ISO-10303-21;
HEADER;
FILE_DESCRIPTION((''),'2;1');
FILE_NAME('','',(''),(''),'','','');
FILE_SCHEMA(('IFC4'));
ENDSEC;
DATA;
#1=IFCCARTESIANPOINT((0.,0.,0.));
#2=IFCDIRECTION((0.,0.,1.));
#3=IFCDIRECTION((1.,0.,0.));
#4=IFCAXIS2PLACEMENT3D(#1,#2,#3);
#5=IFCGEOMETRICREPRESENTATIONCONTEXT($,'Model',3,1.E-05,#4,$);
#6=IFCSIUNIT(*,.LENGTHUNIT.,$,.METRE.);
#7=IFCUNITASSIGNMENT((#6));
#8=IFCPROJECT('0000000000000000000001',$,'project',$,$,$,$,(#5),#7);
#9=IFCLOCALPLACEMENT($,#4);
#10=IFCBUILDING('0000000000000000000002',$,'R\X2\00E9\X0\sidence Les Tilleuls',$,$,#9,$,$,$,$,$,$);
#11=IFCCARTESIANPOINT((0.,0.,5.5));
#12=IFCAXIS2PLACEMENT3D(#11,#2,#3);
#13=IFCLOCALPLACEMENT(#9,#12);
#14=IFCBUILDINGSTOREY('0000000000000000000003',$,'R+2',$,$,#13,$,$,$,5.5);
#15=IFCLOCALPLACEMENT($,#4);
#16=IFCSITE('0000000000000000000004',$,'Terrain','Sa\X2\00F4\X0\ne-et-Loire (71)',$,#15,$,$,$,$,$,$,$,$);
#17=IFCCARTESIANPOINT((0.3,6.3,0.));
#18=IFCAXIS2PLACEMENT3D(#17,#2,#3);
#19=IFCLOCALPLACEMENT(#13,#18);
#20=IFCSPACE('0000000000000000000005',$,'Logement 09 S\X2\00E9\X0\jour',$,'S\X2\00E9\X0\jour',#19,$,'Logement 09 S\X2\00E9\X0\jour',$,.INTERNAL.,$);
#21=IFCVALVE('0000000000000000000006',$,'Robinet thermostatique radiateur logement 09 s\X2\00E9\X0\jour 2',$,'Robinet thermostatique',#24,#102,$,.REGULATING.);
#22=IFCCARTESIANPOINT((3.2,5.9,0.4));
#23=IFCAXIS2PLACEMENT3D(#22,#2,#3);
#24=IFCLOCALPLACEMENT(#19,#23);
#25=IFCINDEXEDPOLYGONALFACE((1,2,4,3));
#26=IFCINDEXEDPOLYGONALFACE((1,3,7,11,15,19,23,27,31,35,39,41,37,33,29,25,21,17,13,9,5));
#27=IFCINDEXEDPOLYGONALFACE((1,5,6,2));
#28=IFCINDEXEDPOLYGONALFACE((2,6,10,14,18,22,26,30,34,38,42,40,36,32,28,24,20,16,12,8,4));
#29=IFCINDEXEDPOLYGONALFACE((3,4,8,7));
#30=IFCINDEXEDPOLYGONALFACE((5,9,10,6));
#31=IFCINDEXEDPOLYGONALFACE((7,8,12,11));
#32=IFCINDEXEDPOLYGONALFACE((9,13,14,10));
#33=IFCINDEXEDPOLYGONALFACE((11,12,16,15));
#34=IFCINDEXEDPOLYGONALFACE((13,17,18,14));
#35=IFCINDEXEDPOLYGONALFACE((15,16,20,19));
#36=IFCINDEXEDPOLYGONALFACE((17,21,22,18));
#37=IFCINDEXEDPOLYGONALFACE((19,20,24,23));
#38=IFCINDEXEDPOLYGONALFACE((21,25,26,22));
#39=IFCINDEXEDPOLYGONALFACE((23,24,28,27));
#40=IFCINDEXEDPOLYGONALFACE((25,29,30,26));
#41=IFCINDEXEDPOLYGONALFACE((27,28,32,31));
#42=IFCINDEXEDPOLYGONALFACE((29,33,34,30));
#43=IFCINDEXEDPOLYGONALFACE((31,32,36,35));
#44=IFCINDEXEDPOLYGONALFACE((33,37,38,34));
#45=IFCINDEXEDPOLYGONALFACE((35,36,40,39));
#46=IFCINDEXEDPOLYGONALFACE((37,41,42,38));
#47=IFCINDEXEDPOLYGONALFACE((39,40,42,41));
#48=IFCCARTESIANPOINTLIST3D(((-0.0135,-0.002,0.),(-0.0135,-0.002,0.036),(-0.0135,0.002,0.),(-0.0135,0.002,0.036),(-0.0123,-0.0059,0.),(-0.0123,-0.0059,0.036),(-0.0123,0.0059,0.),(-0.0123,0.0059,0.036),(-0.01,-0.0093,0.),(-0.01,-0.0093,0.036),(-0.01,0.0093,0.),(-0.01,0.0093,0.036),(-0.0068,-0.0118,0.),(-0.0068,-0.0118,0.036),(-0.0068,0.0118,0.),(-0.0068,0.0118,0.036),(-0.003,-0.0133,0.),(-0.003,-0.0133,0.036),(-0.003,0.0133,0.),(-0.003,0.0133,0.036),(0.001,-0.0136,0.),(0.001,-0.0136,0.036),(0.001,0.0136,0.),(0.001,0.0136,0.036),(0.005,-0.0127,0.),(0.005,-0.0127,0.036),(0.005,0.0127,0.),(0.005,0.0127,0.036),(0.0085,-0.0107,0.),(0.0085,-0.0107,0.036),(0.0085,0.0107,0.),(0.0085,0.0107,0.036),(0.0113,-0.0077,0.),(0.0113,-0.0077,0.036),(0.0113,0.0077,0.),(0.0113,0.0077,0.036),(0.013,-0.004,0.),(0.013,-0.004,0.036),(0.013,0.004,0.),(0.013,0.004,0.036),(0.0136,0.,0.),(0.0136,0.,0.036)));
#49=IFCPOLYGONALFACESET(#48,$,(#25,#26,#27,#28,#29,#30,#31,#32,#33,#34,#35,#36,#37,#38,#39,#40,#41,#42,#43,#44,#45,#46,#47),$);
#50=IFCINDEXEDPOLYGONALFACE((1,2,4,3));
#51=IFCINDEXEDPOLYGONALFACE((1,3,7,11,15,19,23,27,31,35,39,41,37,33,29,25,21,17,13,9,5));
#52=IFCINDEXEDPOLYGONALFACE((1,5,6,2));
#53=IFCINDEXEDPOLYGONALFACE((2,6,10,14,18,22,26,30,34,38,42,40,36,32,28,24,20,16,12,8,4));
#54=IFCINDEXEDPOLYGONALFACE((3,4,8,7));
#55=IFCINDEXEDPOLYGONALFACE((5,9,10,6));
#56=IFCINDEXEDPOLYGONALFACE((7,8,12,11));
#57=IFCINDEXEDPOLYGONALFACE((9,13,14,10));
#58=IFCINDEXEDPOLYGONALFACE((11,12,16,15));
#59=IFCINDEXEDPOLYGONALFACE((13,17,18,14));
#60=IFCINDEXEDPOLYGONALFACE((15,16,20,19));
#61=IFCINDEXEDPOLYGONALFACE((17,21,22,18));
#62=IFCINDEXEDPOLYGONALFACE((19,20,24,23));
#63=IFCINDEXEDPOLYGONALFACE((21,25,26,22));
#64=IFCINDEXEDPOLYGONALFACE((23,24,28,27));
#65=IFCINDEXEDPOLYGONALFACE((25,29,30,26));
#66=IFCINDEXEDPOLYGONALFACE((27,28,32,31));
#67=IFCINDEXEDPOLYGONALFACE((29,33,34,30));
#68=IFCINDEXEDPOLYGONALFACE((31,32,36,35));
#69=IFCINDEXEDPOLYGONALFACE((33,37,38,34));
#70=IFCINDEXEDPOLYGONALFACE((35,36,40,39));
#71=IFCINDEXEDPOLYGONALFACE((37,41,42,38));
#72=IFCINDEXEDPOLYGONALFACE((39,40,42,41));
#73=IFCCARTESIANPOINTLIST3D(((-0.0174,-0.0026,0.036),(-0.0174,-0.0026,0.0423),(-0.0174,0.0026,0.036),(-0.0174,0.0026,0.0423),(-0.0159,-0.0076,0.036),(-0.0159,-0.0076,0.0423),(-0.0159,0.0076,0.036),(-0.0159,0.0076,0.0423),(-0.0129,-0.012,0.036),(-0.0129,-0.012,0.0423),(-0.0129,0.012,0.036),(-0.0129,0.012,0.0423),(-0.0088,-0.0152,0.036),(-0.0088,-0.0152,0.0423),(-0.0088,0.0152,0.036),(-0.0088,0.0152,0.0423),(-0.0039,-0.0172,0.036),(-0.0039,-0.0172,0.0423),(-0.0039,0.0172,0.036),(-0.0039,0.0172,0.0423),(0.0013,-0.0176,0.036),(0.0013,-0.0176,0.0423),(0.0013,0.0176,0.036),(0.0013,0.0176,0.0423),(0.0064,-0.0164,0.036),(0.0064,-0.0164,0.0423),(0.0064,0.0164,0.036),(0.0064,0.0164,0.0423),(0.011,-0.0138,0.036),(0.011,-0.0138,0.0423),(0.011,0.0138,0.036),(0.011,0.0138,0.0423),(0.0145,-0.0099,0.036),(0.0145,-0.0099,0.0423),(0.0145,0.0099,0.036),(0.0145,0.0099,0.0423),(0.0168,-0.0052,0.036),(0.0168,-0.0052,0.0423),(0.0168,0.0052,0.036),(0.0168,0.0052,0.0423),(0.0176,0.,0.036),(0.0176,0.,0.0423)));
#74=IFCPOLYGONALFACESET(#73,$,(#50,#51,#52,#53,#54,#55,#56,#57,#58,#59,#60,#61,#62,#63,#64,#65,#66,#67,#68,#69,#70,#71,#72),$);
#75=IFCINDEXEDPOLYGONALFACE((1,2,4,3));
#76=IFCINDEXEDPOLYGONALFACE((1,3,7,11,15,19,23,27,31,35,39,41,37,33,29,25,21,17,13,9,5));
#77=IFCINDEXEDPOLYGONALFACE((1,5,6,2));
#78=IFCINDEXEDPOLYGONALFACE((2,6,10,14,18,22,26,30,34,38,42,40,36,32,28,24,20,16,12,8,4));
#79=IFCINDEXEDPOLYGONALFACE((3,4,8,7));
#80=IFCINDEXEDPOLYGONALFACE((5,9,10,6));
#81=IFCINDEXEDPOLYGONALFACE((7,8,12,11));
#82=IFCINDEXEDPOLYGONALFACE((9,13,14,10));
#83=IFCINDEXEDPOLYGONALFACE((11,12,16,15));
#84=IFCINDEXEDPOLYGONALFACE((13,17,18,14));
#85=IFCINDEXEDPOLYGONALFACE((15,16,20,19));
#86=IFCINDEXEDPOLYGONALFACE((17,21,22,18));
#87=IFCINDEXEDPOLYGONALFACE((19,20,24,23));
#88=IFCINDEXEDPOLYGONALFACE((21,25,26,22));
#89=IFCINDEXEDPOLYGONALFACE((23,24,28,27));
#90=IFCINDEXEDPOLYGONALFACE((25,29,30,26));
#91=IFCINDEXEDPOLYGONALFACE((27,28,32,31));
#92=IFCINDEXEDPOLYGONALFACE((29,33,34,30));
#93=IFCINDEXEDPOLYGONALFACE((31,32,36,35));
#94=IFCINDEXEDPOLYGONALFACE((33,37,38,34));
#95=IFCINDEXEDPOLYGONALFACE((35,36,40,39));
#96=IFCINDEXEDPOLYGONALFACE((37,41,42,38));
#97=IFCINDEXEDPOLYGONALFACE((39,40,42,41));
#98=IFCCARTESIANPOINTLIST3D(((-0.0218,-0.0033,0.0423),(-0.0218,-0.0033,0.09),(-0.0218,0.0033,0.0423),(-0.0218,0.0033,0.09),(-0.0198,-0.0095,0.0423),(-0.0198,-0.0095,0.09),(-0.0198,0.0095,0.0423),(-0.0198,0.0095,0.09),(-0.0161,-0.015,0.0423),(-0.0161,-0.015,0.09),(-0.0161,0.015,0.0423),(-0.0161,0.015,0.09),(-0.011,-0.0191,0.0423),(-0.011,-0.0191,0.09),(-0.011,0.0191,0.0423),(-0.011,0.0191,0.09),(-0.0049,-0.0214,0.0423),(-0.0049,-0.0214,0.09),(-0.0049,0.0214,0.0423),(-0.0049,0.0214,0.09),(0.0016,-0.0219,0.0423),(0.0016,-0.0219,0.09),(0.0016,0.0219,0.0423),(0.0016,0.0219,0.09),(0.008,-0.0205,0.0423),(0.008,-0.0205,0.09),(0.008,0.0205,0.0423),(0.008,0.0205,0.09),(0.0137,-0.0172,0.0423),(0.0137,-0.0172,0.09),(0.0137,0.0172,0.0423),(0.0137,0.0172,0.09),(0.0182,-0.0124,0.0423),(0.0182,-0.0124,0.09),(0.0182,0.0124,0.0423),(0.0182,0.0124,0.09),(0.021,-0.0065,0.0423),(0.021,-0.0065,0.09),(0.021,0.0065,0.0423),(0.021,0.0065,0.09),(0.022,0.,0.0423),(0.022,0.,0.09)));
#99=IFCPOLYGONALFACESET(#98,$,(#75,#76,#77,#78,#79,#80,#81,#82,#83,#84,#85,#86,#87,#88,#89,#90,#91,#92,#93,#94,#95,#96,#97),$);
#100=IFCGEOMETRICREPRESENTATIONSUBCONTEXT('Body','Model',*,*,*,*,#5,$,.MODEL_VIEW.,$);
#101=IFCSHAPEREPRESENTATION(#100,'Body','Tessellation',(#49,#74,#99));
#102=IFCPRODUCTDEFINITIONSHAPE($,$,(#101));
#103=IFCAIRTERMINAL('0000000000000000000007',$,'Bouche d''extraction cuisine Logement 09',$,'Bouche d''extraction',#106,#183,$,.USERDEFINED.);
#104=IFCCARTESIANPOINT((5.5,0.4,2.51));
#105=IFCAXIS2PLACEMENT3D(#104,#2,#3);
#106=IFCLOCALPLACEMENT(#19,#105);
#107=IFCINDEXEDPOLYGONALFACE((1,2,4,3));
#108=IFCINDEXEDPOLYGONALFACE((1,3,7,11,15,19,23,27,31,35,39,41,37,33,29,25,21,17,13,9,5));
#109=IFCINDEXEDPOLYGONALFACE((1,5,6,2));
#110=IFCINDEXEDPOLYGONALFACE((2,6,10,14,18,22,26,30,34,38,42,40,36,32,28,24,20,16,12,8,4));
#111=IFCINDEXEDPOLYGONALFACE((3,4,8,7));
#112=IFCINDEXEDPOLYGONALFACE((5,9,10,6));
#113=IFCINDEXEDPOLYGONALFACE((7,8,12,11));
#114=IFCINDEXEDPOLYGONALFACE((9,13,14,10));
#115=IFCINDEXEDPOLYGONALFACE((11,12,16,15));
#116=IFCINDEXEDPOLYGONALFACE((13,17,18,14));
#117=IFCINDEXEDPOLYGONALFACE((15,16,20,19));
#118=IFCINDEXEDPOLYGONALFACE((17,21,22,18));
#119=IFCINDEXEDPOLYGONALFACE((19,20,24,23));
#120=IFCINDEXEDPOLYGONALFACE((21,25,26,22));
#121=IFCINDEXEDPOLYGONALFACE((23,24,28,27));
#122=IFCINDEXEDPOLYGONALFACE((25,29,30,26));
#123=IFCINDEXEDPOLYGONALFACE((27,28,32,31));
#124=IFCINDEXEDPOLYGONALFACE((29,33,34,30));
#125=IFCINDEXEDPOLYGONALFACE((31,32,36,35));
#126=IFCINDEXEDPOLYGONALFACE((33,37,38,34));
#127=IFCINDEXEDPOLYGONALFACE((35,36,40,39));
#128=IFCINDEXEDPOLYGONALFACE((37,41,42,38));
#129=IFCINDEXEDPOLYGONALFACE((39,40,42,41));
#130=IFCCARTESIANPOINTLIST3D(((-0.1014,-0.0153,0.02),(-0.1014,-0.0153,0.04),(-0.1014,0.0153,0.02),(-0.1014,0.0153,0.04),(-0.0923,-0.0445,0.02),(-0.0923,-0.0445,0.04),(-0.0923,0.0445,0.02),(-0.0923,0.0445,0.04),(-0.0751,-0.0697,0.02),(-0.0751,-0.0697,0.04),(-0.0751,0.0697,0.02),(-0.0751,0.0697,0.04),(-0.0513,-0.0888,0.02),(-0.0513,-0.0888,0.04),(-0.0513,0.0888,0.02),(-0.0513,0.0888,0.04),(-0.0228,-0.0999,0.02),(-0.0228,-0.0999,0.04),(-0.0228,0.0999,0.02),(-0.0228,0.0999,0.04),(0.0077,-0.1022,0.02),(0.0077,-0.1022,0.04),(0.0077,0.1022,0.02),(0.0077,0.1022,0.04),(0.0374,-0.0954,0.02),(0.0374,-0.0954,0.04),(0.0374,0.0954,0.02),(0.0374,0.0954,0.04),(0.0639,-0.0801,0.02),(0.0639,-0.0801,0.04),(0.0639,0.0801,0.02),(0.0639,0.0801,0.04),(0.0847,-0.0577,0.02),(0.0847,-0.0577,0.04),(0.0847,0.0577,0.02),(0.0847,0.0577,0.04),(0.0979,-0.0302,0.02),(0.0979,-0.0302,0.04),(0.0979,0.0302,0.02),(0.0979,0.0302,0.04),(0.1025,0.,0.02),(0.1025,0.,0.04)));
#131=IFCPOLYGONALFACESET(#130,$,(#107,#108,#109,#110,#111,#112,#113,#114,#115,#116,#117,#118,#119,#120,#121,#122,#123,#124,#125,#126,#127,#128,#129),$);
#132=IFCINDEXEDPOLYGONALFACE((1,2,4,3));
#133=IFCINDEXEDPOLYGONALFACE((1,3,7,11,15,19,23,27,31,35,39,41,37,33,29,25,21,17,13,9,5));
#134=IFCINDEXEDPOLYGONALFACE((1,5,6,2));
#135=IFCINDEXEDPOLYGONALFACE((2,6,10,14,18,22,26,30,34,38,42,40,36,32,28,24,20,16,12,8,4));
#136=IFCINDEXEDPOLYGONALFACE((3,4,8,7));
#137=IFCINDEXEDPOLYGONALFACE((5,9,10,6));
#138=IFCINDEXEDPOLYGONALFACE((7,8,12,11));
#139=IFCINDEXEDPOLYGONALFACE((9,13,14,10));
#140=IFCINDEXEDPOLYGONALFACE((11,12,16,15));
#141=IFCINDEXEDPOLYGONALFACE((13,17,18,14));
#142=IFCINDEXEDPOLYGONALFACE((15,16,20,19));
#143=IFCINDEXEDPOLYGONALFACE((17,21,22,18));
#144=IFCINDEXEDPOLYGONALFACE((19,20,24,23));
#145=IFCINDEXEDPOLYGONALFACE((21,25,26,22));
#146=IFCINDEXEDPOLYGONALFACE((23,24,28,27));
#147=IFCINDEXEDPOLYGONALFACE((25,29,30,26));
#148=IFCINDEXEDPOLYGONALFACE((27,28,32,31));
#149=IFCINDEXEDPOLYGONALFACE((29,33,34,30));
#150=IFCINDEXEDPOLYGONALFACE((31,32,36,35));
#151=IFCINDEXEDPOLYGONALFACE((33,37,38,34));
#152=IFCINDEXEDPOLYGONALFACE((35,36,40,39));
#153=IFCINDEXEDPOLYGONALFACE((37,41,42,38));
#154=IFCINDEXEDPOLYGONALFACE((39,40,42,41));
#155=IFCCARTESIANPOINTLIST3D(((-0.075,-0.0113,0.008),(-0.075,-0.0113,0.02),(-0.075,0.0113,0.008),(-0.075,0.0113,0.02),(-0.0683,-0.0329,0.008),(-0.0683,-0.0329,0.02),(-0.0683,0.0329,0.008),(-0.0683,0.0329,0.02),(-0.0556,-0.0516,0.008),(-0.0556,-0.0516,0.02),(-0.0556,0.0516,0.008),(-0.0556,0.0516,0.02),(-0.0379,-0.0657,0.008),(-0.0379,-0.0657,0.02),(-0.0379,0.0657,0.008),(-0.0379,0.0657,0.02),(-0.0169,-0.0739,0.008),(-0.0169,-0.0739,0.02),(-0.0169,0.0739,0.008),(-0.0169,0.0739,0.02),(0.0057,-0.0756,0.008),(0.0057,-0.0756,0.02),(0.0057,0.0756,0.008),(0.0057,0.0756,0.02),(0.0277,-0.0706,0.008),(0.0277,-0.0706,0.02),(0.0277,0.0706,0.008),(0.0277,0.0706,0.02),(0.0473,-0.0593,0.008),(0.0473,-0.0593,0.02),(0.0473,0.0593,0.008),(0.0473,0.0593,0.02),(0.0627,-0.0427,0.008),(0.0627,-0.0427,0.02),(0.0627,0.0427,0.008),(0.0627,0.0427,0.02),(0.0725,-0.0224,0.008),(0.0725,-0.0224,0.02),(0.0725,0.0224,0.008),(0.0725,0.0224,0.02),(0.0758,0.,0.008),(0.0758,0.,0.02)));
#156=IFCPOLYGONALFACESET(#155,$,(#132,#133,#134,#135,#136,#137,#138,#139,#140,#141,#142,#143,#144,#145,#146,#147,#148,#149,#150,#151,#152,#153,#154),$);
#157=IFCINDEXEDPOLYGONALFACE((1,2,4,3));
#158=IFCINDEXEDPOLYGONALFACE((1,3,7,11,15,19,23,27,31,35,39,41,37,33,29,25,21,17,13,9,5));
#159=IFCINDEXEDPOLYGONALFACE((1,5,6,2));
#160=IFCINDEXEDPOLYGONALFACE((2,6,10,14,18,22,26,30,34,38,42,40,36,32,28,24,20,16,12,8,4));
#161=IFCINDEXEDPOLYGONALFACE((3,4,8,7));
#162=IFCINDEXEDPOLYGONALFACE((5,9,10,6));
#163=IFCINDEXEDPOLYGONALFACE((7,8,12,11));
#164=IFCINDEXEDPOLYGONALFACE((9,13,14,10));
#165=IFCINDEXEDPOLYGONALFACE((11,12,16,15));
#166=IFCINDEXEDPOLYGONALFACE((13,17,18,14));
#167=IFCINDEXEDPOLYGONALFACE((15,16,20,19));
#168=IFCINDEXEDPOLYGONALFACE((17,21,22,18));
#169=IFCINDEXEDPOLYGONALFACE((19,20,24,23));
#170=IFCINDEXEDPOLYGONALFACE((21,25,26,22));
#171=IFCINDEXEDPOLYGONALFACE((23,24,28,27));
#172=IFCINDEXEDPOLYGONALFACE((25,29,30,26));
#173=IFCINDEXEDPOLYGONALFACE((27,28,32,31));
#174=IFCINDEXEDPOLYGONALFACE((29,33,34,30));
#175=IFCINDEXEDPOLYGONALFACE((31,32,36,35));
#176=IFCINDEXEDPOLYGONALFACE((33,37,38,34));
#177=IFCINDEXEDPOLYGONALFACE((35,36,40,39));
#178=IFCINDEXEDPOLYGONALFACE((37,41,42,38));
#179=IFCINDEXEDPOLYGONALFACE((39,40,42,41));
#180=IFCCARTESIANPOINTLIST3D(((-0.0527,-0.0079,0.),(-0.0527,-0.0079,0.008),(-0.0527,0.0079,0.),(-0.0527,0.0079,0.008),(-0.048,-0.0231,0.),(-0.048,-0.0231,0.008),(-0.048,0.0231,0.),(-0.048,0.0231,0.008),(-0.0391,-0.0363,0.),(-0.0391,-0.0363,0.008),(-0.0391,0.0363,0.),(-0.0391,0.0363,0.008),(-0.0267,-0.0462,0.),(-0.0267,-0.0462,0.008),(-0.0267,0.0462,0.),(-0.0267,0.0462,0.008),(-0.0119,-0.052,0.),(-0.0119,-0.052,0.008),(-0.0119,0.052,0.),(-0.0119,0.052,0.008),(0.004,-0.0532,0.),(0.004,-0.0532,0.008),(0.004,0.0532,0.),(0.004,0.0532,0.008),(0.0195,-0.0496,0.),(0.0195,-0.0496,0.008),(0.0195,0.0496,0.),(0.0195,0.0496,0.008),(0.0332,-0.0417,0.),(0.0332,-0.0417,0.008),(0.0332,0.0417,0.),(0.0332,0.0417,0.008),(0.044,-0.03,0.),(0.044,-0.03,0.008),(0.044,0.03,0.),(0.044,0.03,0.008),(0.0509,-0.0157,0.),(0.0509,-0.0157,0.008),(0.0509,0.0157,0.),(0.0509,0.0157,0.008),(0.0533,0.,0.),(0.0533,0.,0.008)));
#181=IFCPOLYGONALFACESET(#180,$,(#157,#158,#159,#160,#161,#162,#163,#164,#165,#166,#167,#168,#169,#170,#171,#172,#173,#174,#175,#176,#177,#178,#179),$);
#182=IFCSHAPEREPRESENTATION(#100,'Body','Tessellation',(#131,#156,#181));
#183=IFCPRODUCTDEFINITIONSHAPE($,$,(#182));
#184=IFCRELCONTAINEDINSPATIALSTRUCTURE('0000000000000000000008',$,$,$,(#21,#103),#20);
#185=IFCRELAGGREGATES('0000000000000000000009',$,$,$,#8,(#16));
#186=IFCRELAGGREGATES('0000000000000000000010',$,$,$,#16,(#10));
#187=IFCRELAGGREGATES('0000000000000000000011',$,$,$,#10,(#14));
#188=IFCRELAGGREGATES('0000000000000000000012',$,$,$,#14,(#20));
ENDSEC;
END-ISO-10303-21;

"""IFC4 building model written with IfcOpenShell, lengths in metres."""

from ifc_helpers import new_model, si_unit, frame, origin_with_axes, place, context, subcontext, project, spatial, circle, extrude, element, save


model = new_model("IFC4")

# Units and contexts
model_context = context("Model", 3, precision=1e-05, world=origin_with_axes())
body_context = subcontext(model_context, "Body", "Model", "MODEL_VIEW")
ifc_project = project(units=[si_unit("LENGTHUNIT", "METRE")], contexts=[model_context])

# Site, building, storey
site_placement = place(None, origin_with_axes())
site = spatial("IfcSite", under=ifc_project, at=site_placement, Name="Terrain", Description="Saône-et-Loire (71)")
building_placement = place(None, origin_with_axes())
building = spatial("IfcBuilding", under=site, at=building_placement, Name="Résidence Les Tilleuls")
storey_placement = place(building_placement, frame((0.0, 0.0, 5.5), z_axis=(0.0, 0.0, 1.0), x_axis=(1.0, 0.0, 0.0)))
storey = spatial("IfcBuildingStorey", under=building, at=storey_placement, Name="R+2", Elevation=5.5)

# Shared definitions
space_placement = place(storey_placement, frame((0.3, 6.3, 0.0), z_axis=(0.0, 0.0, 1.0), x_axis=(1.0, 0.0, 0.0)))
space = spatial("IfcSpace", under=storey, at=space_placement, Name="Logement 09 Séjour", ObjectType="Séjour", LongName="Logement 09 Séjour", PredefinedType="INTERNAL")

# Valve
valve_placement = place(space_placement, frame((3.2, 5.9, 0.4), z_axis=(0.0, 0.0, 1.0), x_axis=(1.0, 0.0, 0.0)))
element("IfcValve", 1, at=valve_placement, inside=space, Name="Robinet thermostatique radiateur logement 09 séjour 2", ObjectType="Robinet thermostatique", PredefinedType="REGULATING", context=body_context, shape_type="SweptSolid", body=[
    extrude(circle(Radius=0.0136), origin_with_axes(), (0.0, 0.0, 1.0), 0.036),
    extrude(circle(Radius=0.0176), frame((0.0, 0.0, 0.036), z_axis=(0.0, 0.0, 1.0), x_axis=(1.0, 0.0, 0.0)), (0.0, 0.0, 1.0), 0.0063),
    extrude(circle(Radius=0.022), frame((0.0, 0.0, 0.0423), z_axis=(0.0, 0.0, 1.0), x_axis=(1.0, 0.0, 0.0)), (0.0, 0.0, 1.0), 0.0477),
])

# Air terminal
air_terminal_placement = place(space_placement, frame((5.5, 0.4, 2.51), z_axis=(0.0, 0.0, 1.0), x_axis=(1.0, 0.0, 0.0)))
element("IfcAirTerminal", 2, at=air_terminal_placement, inside=space, Name="Bouche d'extraction cuisine Logement 09", ObjectType="Bouche d'extraction", PredefinedType="USERDEFINED", context=body_context, shape_type="SweptSolid", body=[
    extrude(circle(Radius=0.1025), frame((0.0, 0.0, 0.02), z_axis=(0.0, 0.0, 1.0), x_axis=(1.0, 0.0, 0.0)), (0.0, 0.0, 1.0), 0.02),
    extrude(circle(Radius=0.0759), frame((0.0, 0.0, 0.008), z_axis=(0.0, 0.0, 1.0), x_axis=(1.0, 0.0, 0.0)), (0.0, 0.0, 1.0), 0.012),
    extrude(circle(Radius=0.0533), origin_with_axes(), (0.0, 0.0, 1.0), 0.008),
])

save(model, "model.ifc")
